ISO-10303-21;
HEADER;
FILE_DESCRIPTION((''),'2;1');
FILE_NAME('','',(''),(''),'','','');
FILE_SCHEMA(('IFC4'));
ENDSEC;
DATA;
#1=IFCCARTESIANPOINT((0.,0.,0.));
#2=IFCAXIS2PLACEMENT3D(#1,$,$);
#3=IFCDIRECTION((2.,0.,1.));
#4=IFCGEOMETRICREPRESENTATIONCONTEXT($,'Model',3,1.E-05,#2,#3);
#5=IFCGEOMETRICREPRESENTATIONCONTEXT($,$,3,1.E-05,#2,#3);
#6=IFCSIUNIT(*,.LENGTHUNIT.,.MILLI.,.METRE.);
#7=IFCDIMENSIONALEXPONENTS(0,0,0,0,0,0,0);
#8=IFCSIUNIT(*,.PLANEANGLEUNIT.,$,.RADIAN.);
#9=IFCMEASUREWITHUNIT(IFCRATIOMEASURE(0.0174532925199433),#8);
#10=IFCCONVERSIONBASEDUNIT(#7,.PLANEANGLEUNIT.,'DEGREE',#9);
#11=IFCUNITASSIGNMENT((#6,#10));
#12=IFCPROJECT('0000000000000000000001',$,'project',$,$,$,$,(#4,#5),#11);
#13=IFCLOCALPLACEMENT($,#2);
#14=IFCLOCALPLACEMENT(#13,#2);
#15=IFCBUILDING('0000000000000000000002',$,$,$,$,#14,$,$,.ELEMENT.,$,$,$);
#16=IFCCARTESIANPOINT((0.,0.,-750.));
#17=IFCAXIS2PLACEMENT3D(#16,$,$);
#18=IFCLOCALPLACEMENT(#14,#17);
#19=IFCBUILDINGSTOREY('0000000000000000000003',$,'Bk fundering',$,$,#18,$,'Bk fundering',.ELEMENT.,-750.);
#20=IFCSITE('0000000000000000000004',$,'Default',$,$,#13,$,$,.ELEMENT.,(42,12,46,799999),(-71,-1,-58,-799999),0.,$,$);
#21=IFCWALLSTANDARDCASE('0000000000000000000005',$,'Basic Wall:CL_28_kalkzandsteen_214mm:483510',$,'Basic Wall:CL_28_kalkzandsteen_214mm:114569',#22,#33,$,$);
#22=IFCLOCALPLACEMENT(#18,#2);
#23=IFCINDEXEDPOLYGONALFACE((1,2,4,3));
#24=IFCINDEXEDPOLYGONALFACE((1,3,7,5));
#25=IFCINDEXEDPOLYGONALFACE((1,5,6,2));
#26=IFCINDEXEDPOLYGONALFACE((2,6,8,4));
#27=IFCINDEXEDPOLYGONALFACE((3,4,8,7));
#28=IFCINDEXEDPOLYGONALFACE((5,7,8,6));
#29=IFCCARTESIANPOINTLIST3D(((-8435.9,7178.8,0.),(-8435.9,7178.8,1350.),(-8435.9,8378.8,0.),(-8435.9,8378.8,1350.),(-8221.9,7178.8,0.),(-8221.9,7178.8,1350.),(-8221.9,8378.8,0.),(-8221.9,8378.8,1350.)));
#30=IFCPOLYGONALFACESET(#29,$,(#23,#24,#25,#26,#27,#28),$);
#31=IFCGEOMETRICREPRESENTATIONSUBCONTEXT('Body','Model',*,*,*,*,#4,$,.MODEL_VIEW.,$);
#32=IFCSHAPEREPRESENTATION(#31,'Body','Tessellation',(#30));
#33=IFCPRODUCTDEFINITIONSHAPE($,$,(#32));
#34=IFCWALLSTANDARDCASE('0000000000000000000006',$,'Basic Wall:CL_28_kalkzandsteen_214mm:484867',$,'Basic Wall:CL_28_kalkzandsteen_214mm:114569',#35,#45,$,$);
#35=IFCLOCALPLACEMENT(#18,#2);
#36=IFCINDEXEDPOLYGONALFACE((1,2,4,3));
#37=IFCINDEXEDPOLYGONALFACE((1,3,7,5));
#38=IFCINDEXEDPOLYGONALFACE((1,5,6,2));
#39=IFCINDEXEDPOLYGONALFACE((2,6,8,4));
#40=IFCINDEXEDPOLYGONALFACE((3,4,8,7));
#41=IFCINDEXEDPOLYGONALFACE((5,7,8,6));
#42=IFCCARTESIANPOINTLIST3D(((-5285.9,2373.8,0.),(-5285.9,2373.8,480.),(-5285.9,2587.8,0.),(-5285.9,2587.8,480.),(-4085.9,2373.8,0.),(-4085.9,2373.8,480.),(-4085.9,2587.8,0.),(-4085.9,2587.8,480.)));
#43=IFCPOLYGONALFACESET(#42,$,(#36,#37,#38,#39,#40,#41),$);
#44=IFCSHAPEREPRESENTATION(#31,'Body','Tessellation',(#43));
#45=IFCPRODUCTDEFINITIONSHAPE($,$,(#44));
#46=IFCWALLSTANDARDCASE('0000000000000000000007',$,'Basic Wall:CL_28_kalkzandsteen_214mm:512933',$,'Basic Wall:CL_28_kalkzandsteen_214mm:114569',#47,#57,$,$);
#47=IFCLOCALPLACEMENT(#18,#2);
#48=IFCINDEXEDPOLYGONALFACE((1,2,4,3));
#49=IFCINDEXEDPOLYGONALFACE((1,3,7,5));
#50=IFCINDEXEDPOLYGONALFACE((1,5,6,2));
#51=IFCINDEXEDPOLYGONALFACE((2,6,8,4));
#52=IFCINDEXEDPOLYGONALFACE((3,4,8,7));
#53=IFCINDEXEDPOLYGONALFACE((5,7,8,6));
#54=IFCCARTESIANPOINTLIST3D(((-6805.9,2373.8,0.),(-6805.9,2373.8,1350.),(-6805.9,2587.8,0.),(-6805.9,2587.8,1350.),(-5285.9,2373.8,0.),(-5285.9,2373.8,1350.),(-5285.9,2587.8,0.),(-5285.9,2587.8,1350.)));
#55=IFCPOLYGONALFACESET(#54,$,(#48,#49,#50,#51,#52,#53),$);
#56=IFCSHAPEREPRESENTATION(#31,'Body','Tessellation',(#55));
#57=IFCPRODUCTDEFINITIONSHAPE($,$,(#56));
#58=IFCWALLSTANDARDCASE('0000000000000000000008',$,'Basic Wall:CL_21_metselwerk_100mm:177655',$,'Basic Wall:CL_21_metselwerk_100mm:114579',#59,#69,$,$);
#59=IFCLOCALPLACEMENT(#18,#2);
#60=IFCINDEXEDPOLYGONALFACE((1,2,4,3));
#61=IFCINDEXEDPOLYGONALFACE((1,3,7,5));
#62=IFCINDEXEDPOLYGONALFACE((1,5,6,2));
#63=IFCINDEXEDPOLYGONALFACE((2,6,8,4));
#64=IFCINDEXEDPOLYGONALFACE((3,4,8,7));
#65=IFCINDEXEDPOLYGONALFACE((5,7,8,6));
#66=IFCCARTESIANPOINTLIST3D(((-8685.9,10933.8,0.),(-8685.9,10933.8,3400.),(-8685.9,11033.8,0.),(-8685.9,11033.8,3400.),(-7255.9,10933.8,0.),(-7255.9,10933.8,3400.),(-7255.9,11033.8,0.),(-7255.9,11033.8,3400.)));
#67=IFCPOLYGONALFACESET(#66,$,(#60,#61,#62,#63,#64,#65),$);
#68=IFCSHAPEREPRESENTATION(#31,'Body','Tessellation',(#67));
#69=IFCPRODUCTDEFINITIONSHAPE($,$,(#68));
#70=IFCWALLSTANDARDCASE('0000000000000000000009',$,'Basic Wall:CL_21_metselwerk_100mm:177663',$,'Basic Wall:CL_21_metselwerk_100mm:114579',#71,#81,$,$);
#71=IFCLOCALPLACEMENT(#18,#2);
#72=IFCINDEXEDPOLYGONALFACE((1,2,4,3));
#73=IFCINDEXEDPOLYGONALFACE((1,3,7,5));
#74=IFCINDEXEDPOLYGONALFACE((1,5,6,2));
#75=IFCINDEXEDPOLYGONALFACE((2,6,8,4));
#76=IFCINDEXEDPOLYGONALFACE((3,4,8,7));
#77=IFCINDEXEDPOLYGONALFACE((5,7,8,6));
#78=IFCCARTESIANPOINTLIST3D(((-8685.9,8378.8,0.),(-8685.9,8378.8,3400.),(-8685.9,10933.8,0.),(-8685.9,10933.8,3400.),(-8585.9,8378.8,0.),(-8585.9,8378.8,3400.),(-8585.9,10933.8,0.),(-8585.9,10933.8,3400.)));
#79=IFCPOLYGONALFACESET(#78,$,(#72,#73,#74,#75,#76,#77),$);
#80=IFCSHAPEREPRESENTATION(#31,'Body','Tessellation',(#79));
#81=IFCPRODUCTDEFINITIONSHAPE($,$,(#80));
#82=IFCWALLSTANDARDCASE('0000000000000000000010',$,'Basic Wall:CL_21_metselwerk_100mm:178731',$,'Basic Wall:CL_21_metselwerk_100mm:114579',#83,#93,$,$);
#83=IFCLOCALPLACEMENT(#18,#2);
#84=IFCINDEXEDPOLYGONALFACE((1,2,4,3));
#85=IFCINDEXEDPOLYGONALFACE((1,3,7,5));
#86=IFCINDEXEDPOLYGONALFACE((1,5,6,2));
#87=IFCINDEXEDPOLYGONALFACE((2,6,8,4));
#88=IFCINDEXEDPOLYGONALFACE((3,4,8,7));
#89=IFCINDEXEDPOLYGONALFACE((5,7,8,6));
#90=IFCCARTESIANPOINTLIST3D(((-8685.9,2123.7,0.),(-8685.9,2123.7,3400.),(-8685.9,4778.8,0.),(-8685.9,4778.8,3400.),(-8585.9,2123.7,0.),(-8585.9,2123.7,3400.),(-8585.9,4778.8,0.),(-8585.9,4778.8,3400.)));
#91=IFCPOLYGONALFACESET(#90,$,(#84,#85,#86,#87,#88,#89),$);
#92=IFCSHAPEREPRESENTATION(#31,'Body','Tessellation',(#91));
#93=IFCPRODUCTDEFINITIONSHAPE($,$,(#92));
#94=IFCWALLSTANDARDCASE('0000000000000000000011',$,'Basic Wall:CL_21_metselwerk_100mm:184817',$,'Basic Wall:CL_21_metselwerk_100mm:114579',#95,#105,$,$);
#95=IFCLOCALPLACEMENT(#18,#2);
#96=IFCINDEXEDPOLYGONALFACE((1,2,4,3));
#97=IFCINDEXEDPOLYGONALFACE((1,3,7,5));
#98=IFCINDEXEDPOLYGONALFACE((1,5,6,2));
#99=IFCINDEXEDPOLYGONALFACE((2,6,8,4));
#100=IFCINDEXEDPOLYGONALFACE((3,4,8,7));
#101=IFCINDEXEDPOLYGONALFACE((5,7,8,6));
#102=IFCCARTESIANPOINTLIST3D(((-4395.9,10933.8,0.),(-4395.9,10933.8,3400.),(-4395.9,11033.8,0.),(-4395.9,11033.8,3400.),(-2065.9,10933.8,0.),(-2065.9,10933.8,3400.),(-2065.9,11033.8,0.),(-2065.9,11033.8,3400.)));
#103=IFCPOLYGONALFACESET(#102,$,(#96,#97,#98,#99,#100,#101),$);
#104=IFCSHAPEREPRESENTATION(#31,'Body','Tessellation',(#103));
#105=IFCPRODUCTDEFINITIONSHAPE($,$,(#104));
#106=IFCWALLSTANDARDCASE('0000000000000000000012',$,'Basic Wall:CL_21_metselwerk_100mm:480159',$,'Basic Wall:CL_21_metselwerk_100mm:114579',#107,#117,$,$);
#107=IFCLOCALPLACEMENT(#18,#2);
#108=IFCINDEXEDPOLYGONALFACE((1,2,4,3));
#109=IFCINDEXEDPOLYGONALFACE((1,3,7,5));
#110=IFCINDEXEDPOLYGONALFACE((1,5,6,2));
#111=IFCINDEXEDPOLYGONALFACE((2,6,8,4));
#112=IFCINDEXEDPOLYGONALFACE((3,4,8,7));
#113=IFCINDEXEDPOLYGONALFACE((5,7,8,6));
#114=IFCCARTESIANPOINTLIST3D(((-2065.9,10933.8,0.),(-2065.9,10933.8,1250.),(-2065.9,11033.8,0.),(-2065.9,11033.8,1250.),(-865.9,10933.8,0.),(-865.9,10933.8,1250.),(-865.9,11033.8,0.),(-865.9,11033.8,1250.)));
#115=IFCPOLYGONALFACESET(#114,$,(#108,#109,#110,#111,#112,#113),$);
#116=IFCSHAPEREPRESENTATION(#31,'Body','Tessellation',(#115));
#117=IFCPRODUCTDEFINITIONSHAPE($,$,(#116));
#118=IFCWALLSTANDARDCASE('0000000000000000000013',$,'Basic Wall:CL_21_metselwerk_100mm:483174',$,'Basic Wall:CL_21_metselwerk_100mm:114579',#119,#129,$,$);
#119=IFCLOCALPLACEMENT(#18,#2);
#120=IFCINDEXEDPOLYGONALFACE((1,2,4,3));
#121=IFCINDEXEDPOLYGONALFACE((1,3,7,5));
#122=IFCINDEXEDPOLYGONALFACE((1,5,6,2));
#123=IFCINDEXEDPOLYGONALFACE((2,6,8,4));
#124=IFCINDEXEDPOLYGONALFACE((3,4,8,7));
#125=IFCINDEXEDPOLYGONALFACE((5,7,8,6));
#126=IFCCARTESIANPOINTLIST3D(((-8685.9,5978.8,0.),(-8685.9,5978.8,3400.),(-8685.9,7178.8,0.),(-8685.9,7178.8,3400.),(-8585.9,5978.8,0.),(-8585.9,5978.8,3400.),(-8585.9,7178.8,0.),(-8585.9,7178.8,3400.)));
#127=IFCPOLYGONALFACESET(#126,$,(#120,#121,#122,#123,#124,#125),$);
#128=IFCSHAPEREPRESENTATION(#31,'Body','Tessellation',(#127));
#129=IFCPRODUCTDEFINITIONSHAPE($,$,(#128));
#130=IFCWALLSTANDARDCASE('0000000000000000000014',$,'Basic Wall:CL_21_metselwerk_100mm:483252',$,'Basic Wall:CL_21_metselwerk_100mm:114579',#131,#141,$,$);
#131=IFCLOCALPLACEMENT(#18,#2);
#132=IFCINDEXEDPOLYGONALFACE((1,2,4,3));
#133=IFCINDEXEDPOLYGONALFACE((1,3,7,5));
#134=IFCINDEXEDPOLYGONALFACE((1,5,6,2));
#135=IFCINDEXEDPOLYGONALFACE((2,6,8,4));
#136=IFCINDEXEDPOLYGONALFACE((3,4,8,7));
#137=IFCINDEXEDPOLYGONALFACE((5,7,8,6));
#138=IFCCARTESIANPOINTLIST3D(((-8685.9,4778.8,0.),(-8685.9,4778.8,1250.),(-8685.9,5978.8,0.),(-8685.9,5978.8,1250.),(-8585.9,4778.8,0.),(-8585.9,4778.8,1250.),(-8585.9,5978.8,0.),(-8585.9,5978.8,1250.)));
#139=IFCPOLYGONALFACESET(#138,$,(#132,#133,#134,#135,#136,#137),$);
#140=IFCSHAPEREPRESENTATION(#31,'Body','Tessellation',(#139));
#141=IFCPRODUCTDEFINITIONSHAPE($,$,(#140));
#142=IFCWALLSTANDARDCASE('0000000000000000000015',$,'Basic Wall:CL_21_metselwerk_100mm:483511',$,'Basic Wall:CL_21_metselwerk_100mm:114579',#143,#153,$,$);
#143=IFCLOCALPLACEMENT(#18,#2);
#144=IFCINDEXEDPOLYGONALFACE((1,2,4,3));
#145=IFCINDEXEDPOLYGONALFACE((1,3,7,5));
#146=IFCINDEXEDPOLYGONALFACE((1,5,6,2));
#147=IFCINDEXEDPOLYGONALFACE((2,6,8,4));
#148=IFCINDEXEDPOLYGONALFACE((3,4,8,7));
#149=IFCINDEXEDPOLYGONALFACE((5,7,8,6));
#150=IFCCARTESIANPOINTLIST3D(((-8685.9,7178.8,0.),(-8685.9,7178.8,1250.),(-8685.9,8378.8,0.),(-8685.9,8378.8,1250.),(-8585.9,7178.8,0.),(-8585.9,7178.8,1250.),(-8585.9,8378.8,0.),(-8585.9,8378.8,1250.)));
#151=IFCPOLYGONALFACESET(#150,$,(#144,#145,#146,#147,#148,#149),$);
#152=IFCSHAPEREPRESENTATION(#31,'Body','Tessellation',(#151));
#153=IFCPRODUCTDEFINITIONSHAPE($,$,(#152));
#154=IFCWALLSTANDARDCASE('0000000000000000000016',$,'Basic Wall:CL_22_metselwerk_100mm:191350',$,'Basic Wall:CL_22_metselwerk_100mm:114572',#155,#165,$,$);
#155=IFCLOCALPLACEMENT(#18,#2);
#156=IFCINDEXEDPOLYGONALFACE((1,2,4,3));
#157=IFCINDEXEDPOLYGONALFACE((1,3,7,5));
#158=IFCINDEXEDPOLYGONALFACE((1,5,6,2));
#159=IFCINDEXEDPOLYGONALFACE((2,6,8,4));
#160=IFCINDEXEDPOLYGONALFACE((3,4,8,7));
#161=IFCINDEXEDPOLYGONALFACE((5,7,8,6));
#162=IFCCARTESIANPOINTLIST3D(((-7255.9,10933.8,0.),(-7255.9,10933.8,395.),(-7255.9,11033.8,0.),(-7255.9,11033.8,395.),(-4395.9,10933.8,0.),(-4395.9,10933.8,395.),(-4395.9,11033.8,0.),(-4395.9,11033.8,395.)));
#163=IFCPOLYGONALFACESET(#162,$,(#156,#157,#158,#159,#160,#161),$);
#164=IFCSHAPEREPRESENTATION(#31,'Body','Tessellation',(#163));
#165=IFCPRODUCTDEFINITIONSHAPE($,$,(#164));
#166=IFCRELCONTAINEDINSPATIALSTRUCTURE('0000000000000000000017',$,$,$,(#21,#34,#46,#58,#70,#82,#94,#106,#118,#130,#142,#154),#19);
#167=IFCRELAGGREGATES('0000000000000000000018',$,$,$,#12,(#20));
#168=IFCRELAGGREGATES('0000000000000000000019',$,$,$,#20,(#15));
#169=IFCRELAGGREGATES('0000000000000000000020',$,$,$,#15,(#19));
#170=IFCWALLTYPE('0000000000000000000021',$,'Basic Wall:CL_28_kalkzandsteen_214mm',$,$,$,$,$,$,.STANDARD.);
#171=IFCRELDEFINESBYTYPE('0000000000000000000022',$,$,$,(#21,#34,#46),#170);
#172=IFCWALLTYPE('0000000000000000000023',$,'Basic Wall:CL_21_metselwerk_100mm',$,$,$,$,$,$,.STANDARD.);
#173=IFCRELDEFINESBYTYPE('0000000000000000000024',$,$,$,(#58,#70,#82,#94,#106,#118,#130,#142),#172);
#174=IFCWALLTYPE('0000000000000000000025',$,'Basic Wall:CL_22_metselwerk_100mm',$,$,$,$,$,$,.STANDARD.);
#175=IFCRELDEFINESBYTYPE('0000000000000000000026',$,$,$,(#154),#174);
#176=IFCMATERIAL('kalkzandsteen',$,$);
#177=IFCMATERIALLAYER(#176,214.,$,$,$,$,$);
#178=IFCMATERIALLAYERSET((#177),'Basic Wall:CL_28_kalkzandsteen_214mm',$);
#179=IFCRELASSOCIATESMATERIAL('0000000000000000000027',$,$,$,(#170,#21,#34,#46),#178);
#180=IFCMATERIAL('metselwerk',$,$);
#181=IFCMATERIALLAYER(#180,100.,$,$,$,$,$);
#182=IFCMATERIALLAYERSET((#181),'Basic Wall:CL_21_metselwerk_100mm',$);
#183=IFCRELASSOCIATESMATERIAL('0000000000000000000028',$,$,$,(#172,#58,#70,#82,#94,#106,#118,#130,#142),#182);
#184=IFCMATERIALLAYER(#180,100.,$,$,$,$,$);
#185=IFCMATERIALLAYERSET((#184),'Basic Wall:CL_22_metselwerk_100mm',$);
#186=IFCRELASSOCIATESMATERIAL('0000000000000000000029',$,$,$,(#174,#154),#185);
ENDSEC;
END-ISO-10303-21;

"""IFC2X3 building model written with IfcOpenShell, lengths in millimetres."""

from ifc_helpers import new_model, entity, si_unit, converted_unit, direction, frame, frame_2d, origin, place, context, subcontext, project, spatial, rectangle, extrude, material, layer, layer_set, layer_usage, type_object, element, save


model = new_model("IFC2X3")

# Units and contexts
model_context = context("Model", 3, precision=1e-05, world=origin(), true_north=direction((2.0, 0.0, 1.0)))
context_of_model = context(None, 3, precision=1e-05, world=origin(), true_north=direction((2.0, 0.0, 1.0)))
body_context = subcontext(model_context, "Body", "Model", "MODEL_VIEW")
ifc_project = project(units=[si_unit("LENGTHUNIT", "METRE", prefix="MILLI"), converted_unit("PLANEANGLEUNIT", "DEGREE", entity("IfcRatioMeasure", 0.0174532925199433), si_unit("PLANEANGLEUNIT", "RADIAN"), dimensions=[0, 0, 0, 0, 0, 0, 0])], contexts=[model_context, context_of_model])

# Site, building, storey
site_placement = place(None, origin())
site = spatial("IfcSite", under=ifc_project, at=site_placement, Name="Default", CompositionType="ELEMENT", RefLatitude=(42, 12, 46, 799999), RefLongitude=(-71, -1, -58, -799999), RefElevation=0.0)
building_placement = place(site_placement, origin())
building = spatial("IfcBuilding", under=site, at=building_placement, CompositionType="ELEMENT")
storey_placement = place(building_placement, frame((0.0, 0.0, -750.0)))
storey = spatial("IfcBuildingStorey", under=building, at=storey_placement, Name="Bk fundering", LongName="Bk fundering", CompositionType="ELEMENT", Elevation=-750.0)

# Shared definitions
ifc_material_1 = material(Name="kalkzandsteen")
ifc_layer_1 = layer(ifc_material_1, 214.0)
ifc_layer_set_1 = layer_set([ifc_layer_1], Name="Basic Wall:CL_28_kalkzandsteen_214mm")
wall_type_1 = type_object("IfcWallType", Name="Basic Wall:CL_28_kalkzandsteen_214mm", PredefinedType="STANDARD", material=ifc_layer_set_1)

# Walls
ifc_layer_usage_1 = layer_usage(ifc_layer_set_1, "AXIS2", "NEGATIVE", 107.0)
wall_1_placement = place(storey_placement, frame((-8328.9, 8378.8, 0.0), z_axis=(0.0, 0.0, 1.0), x_axis=(0.0, -1.0, 0.0)))
element("IfcWallStandardCase", 1, at=wall_1_placement, inside=storey, type_object=wall_type_1, material=ifc_layer_usage_1, Name="Basic Wall:CL_28_kalkzandsteen_214mm:483510", ObjectType="Basic Wall:CL_28_kalkzandsteen_214mm:114569", context=body_context, shape_type="SweptSolid", body=[
    extrude(rectangle(XDim=1200.0, YDim=214.0, at=frame_2d((600.0, 0.0), x_axis=(-1.0, 0.0))), origin(), (0.0, 0.0, 1.0), 1350.0),
])
ifc_layer_usage_2 = layer_usage(ifc_layer_set_1, "AXIS2", "NEGATIVE", 107.0)
wall_2_placement = place(storey_placement, frame((-5285.9, 2480.8, 0.0)))
element("IfcWallStandardCase", 2, at=wall_2_placement, inside=storey, type_object=wall_type_1, material=ifc_layer_usage_2, Name="Basic Wall:CL_28_kalkzandsteen_214mm:484867", ObjectType="Basic Wall:CL_28_kalkzandsteen_214mm:114569", context=body_context, shape_type="SweptSolid", body=[
    extrude(rectangle(XDim=1200.0, YDim=214.0, at=frame_2d((600.0, 0.0), x_axis=(-1.0, 0.0))), origin(), (0.0, 0.0, 1.0), 480.0),
])
ifc_layer_usage_3 = layer_usage(ifc_layer_set_1, "AXIS2", "NEGATIVE", 107.0)
wall_3_placement = place(storey_placement, frame((-6805.9, 2480.8, 0.0)))
element("IfcWallStandardCase", 3, at=wall_3_placement, inside=storey, type_object=wall_type_1, material=ifc_layer_usage_3, Name="Basic Wall:CL_28_kalkzandsteen_214mm:512933", ObjectType="Basic Wall:CL_28_kalkzandsteen_214mm:114569", context=body_context, shape_type="SweptSolid", body=[
    extrude(rectangle(XDim=1520.0, YDim=214.0, at=frame_2d((760.0, 0.0), x_axis=(-1.0, 0.0))), origin(), (0.0, 0.0, 1.0), 1350.0),
])
ifc_material_2 = material(Name="metselwerk")
ifc_layer_2 = layer(ifc_material_2, 100.0)
ifc_layer_set_2 = layer_set([ifc_layer_2], Name="Basic Wall:CL_21_metselwerk_100mm")
ifc_layer_usage_4 = layer_usage(ifc_layer_set_2, "AXIS2", "NEGATIVE", 50.0)
wall_type_2 = type_object("IfcWallType", Name="Basic Wall:CL_21_metselwerk_100mm", PredefinedType="STANDARD", material=ifc_layer_set_2)
wall_4_placement = place(storey_placement, frame((-7255.9, 10983.8, 0.0), z_axis=(0.0, 0.0, 1.0), x_axis=(-1.0, 0.0, 0.0)))
element("IfcWallStandardCase", 4, at=wall_4_placement, inside=storey, type_object=wall_type_2, material=ifc_layer_usage_4, Name="Basic Wall:CL_21_metselwerk_100mm:177655", ObjectType="Basic Wall:CL_21_metselwerk_100mm:114579", context=body_context, shape_type="SweptSolid", body=[
    extrude(rectangle(XDim=1430.0, YDim=100.0, at=frame_2d((715.0, 0.0), x_axis=(-1.0, 0.0))), origin(), (0.0, 0.0, 1.0), 3400.0),
])
ifc_layer_usage_5 = layer_usage(ifc_layer_set_2, "AXIS2", "NEGATIVE", 50.0)
wall_5_placement = place(storey_placement, frame((-8635.9, 10933.8, 0.0), z_axis=(0.0, 0.0, 1.0), x_axis=(0.0, -1.0, 0.0)))
element("IfcWallStandardCase", 5, at=wall_5_placement, inside=storey, type_object=wall_type_2, material=ifc_layer_usage_5, Name="Basic Wall:CL_21_metselwerk_100mm:177663", ObjectType="Basic Wall:CL_21_metselwerk_100mm:114579", context=body_context, shape_type="SweptSolid", body=[
    extrude(rectangle(XDim=2555.0, YDim=100.0, at=frame_2d((1277.5, 0.0), x_axis=(-1.0, 0.0))), origin(), (0.0, 0.0, 1.0), 3400.0),
])
ifc_layer_usage_6 = layer_usage(ifc_layer_set_2, "AXIS2", "NEGATIVE", 50.0)
wall_6_placement = place(storey_placement, frame((-8635.9, 4778.8, 0.0), z_axis=(0.0, 0.0, 1.0), x_axis=(0.0, -1.0, 0.0)))
element("IfcWallStandardCase", 6, at=wall_6_placement, inside=storey, type_object=wall_type_2, material=ifc_layer_usage_6, Name="Basic Wall:CL_21_metselwerk_100mm:178731", ObjectType="Basic Wall:CL_21_metselwerk_100mm:114579", context=body_context, shape_type="SweptSolid", body=[
    extrude(rectangle(XDim=2655.1, YDim=100.0, at=frame_2d((1327.5, 0.0), x_axis=(-1.0, 0.0))), origin(), (0.0, 0.0, 1.0), 3400.0),
])
ifc_layer_usage_7 = layer_usage(ifc_layer_set_2, "AXIS2", "NEGATIVE", 50.0)
wall_7_placement = place(storey_placement, frame((-2065.9, 10983.8, 0.0), z_axis=(0.0, 0.0, 1.0), x_axis=(-1.0, 0.0, 0.0)))
element("IfcWallStandardCase", 7, at=wall_7_placement, inside=storey, type_object=wall_type_2, material=ifc_layer_usage_7, Name="Basic Wall:CL_21_metselwerk_100mm:184817", ObjectType="Basic Wall:CL_21_metselwerk_100mm:114579", context=body_context, shape_type="SweptSolid", body=[
    extrude(rectangle(XDim=2330.0, YDim=100.0, at=frame_2d((1165.0, 0.0), x_axis=(-1.0, 0.0))), origin(), (0.0, 0.0, 1.0), 3400.0),
])
ifc_layer_usage_8 = layer_usage(ifc_layer_set_2, "AXIS2", "NEGATIVE", 50.0)
wall_8_placement = place(storey_placement, frame((-865.9, 10983.8, 0.0), z_axis=(0.0, 0.0, 1.0), x_axis=(-1.0, 0.0, 0.0)))
element("IfcWallStandardCase", 8, at=wall_8_placement, inside=storey, type_object=wall_type_2, material=ifc_layer_usage_8, Name="Basic Wall:CL_21_metselwerk_100mm:480159", ObjectType="Basic Wall:CL_21_metselwerk_100mm:114579", context=body_context, shape_type="SweptSolid", body=[
    extrude(rectangle(XDim=1200.0, YDim=100.0, at=frame_2d((600.0, 0.0), x_axis=(-1.0, 0.0))), origin(), (0.0, 0.0, 1.0), 1250.0),
])
ifc_layer_usage_9 = layer_usage(ifc_layer_set_2, "AXIS2", "NEGATIVE", 50.0)
wall_9_placement = place(storey_placement, frame((-8635.9, 7178.8, 0.0), z_axis=(0.0, 0.0, 1.0), x_axis=(0.0, -1.0, 0.0)))
element("IfcWallStandardCase", 9, at=wall_9_placement, inside=storey, type_object=wall_type_2, material=ifc_layer_usage_9, Name="Basic Wall:CL_21_metselwerk_100mm:483174", ObjectType="Basic Wall:CL_21_metselwerk_100mm:114579", context=body_context, shape_type="SweptSolid", body=[
    extrude(rectangle(XDim=1200.0, YDim=100.0, at=frame_2d((600.0, 0.0), x_axis=(-1.0, 0.0))), origin(), (0.0, 0.0, 1.0), 3400.0),
])
ifc_layer_usage_10 = layer_usage(ifc_layer_set_2, "AXIS2", "NEGATIVE", 50.0)
wall_10_placement = place(storey_placement, frame((-8635.9, 5978.8, 0.0), z_axis=(0.0, 0.0, 1.0), x_axis=(0.0, -1.0, 0.0)))
element("IfcWallStandardCase", 10, at=wall_10_placement, inside=storey, type_object=wall_type_2, material=ifc_layer_usage_10, Name="Basic Wall:CL_21_metselwerk_100mm:483252", ObjectType="Basic Wall:CL_21_metselwerk_100mm:114579", context=body_context, shape_type="SweptSolid", body=[
    extrude(rectangle(XDim=1200.0, YDim=100.0, at=frame_2d((600.0, 0.0), x_axis=(-1.0, 0.0))), origin(), (0.0, 0.0, 1.0), 1250.0),
])
ifc_layer_usage_11 = layer_usage(ifc_layer_set_2, "AXIS2", "NEGATIVE", 50.0)
wall_11_placement = place(storey_placement, frame((-8635.9, 8378.8, 0.0), z_axis=(0.0, 0.0, 1.0), x_axis=(0.0, -1.0, 0.0)))
element("IfcWallStandardCase", 11, at=wall_11_placement, inside=storey, type_object=wall_type_2, material=ifc_layer_usage_11, Name="Basic Wall:CL_21_metselwerk_100mm:483511", ObjectType="Basic Wall:CL_21_metselwerk_100mm:114579", context=body_context, shape_type="SweptSolid", body=[
    extrude(rectangle(XDim=1200.0, YDim=100.0, at=frame_2d((600.0, 0.0), x_axis=(-1.0, 0.0))), origin(), (0.0, 0.0, 1.0), 1250.0),
])
ifc_layer_3 = layer(ifc_material_2, 100.0)
ifc_layer_set_3 = layer_set([ifc_layer_3], Name="Basic Wall:CL_22_metselwerk_100mm")
ifc_layer_usage_12 = layer_usage(ifc_layer_set_3, "AXIS2", "NEGATIVE", 50.0)
wall_type_3 = type_object("IfcWallType", Name="Basic Wall:CL_22_metselwerk_100mm", PredefinedType="STANDARD", material=ifc_layer_set_3)
wall_12_placement = place(storey_placement, frame((-4395.9, 10983.8, 0.0), z_axis=(0.0, 0.0, 1.0), x_axis=(-1.0, 0.0, 0.0)))
element("IfcWallStandardCase", 12, at=wall_12_placement, inside=storey, type_object=wall_type_3, material=ifc_layer_usage_12, Name="Basic Wall:CL_22_metselwerk_100mm:191350", ObjectType="Basic Wall:CL_22_metselwerk_100mm:114572", context=body_context, shape_type="SweptSolid", body=[
    extrude(rectangle(XDim=2860.0, YDim=100.0, at=frame_2d((1430.0, 0.0), x_axis=(-1.0, 0.0))), origin(), (0.0, 0.0, 1.0), 395.0),
])

save(model, "model.ifc")
